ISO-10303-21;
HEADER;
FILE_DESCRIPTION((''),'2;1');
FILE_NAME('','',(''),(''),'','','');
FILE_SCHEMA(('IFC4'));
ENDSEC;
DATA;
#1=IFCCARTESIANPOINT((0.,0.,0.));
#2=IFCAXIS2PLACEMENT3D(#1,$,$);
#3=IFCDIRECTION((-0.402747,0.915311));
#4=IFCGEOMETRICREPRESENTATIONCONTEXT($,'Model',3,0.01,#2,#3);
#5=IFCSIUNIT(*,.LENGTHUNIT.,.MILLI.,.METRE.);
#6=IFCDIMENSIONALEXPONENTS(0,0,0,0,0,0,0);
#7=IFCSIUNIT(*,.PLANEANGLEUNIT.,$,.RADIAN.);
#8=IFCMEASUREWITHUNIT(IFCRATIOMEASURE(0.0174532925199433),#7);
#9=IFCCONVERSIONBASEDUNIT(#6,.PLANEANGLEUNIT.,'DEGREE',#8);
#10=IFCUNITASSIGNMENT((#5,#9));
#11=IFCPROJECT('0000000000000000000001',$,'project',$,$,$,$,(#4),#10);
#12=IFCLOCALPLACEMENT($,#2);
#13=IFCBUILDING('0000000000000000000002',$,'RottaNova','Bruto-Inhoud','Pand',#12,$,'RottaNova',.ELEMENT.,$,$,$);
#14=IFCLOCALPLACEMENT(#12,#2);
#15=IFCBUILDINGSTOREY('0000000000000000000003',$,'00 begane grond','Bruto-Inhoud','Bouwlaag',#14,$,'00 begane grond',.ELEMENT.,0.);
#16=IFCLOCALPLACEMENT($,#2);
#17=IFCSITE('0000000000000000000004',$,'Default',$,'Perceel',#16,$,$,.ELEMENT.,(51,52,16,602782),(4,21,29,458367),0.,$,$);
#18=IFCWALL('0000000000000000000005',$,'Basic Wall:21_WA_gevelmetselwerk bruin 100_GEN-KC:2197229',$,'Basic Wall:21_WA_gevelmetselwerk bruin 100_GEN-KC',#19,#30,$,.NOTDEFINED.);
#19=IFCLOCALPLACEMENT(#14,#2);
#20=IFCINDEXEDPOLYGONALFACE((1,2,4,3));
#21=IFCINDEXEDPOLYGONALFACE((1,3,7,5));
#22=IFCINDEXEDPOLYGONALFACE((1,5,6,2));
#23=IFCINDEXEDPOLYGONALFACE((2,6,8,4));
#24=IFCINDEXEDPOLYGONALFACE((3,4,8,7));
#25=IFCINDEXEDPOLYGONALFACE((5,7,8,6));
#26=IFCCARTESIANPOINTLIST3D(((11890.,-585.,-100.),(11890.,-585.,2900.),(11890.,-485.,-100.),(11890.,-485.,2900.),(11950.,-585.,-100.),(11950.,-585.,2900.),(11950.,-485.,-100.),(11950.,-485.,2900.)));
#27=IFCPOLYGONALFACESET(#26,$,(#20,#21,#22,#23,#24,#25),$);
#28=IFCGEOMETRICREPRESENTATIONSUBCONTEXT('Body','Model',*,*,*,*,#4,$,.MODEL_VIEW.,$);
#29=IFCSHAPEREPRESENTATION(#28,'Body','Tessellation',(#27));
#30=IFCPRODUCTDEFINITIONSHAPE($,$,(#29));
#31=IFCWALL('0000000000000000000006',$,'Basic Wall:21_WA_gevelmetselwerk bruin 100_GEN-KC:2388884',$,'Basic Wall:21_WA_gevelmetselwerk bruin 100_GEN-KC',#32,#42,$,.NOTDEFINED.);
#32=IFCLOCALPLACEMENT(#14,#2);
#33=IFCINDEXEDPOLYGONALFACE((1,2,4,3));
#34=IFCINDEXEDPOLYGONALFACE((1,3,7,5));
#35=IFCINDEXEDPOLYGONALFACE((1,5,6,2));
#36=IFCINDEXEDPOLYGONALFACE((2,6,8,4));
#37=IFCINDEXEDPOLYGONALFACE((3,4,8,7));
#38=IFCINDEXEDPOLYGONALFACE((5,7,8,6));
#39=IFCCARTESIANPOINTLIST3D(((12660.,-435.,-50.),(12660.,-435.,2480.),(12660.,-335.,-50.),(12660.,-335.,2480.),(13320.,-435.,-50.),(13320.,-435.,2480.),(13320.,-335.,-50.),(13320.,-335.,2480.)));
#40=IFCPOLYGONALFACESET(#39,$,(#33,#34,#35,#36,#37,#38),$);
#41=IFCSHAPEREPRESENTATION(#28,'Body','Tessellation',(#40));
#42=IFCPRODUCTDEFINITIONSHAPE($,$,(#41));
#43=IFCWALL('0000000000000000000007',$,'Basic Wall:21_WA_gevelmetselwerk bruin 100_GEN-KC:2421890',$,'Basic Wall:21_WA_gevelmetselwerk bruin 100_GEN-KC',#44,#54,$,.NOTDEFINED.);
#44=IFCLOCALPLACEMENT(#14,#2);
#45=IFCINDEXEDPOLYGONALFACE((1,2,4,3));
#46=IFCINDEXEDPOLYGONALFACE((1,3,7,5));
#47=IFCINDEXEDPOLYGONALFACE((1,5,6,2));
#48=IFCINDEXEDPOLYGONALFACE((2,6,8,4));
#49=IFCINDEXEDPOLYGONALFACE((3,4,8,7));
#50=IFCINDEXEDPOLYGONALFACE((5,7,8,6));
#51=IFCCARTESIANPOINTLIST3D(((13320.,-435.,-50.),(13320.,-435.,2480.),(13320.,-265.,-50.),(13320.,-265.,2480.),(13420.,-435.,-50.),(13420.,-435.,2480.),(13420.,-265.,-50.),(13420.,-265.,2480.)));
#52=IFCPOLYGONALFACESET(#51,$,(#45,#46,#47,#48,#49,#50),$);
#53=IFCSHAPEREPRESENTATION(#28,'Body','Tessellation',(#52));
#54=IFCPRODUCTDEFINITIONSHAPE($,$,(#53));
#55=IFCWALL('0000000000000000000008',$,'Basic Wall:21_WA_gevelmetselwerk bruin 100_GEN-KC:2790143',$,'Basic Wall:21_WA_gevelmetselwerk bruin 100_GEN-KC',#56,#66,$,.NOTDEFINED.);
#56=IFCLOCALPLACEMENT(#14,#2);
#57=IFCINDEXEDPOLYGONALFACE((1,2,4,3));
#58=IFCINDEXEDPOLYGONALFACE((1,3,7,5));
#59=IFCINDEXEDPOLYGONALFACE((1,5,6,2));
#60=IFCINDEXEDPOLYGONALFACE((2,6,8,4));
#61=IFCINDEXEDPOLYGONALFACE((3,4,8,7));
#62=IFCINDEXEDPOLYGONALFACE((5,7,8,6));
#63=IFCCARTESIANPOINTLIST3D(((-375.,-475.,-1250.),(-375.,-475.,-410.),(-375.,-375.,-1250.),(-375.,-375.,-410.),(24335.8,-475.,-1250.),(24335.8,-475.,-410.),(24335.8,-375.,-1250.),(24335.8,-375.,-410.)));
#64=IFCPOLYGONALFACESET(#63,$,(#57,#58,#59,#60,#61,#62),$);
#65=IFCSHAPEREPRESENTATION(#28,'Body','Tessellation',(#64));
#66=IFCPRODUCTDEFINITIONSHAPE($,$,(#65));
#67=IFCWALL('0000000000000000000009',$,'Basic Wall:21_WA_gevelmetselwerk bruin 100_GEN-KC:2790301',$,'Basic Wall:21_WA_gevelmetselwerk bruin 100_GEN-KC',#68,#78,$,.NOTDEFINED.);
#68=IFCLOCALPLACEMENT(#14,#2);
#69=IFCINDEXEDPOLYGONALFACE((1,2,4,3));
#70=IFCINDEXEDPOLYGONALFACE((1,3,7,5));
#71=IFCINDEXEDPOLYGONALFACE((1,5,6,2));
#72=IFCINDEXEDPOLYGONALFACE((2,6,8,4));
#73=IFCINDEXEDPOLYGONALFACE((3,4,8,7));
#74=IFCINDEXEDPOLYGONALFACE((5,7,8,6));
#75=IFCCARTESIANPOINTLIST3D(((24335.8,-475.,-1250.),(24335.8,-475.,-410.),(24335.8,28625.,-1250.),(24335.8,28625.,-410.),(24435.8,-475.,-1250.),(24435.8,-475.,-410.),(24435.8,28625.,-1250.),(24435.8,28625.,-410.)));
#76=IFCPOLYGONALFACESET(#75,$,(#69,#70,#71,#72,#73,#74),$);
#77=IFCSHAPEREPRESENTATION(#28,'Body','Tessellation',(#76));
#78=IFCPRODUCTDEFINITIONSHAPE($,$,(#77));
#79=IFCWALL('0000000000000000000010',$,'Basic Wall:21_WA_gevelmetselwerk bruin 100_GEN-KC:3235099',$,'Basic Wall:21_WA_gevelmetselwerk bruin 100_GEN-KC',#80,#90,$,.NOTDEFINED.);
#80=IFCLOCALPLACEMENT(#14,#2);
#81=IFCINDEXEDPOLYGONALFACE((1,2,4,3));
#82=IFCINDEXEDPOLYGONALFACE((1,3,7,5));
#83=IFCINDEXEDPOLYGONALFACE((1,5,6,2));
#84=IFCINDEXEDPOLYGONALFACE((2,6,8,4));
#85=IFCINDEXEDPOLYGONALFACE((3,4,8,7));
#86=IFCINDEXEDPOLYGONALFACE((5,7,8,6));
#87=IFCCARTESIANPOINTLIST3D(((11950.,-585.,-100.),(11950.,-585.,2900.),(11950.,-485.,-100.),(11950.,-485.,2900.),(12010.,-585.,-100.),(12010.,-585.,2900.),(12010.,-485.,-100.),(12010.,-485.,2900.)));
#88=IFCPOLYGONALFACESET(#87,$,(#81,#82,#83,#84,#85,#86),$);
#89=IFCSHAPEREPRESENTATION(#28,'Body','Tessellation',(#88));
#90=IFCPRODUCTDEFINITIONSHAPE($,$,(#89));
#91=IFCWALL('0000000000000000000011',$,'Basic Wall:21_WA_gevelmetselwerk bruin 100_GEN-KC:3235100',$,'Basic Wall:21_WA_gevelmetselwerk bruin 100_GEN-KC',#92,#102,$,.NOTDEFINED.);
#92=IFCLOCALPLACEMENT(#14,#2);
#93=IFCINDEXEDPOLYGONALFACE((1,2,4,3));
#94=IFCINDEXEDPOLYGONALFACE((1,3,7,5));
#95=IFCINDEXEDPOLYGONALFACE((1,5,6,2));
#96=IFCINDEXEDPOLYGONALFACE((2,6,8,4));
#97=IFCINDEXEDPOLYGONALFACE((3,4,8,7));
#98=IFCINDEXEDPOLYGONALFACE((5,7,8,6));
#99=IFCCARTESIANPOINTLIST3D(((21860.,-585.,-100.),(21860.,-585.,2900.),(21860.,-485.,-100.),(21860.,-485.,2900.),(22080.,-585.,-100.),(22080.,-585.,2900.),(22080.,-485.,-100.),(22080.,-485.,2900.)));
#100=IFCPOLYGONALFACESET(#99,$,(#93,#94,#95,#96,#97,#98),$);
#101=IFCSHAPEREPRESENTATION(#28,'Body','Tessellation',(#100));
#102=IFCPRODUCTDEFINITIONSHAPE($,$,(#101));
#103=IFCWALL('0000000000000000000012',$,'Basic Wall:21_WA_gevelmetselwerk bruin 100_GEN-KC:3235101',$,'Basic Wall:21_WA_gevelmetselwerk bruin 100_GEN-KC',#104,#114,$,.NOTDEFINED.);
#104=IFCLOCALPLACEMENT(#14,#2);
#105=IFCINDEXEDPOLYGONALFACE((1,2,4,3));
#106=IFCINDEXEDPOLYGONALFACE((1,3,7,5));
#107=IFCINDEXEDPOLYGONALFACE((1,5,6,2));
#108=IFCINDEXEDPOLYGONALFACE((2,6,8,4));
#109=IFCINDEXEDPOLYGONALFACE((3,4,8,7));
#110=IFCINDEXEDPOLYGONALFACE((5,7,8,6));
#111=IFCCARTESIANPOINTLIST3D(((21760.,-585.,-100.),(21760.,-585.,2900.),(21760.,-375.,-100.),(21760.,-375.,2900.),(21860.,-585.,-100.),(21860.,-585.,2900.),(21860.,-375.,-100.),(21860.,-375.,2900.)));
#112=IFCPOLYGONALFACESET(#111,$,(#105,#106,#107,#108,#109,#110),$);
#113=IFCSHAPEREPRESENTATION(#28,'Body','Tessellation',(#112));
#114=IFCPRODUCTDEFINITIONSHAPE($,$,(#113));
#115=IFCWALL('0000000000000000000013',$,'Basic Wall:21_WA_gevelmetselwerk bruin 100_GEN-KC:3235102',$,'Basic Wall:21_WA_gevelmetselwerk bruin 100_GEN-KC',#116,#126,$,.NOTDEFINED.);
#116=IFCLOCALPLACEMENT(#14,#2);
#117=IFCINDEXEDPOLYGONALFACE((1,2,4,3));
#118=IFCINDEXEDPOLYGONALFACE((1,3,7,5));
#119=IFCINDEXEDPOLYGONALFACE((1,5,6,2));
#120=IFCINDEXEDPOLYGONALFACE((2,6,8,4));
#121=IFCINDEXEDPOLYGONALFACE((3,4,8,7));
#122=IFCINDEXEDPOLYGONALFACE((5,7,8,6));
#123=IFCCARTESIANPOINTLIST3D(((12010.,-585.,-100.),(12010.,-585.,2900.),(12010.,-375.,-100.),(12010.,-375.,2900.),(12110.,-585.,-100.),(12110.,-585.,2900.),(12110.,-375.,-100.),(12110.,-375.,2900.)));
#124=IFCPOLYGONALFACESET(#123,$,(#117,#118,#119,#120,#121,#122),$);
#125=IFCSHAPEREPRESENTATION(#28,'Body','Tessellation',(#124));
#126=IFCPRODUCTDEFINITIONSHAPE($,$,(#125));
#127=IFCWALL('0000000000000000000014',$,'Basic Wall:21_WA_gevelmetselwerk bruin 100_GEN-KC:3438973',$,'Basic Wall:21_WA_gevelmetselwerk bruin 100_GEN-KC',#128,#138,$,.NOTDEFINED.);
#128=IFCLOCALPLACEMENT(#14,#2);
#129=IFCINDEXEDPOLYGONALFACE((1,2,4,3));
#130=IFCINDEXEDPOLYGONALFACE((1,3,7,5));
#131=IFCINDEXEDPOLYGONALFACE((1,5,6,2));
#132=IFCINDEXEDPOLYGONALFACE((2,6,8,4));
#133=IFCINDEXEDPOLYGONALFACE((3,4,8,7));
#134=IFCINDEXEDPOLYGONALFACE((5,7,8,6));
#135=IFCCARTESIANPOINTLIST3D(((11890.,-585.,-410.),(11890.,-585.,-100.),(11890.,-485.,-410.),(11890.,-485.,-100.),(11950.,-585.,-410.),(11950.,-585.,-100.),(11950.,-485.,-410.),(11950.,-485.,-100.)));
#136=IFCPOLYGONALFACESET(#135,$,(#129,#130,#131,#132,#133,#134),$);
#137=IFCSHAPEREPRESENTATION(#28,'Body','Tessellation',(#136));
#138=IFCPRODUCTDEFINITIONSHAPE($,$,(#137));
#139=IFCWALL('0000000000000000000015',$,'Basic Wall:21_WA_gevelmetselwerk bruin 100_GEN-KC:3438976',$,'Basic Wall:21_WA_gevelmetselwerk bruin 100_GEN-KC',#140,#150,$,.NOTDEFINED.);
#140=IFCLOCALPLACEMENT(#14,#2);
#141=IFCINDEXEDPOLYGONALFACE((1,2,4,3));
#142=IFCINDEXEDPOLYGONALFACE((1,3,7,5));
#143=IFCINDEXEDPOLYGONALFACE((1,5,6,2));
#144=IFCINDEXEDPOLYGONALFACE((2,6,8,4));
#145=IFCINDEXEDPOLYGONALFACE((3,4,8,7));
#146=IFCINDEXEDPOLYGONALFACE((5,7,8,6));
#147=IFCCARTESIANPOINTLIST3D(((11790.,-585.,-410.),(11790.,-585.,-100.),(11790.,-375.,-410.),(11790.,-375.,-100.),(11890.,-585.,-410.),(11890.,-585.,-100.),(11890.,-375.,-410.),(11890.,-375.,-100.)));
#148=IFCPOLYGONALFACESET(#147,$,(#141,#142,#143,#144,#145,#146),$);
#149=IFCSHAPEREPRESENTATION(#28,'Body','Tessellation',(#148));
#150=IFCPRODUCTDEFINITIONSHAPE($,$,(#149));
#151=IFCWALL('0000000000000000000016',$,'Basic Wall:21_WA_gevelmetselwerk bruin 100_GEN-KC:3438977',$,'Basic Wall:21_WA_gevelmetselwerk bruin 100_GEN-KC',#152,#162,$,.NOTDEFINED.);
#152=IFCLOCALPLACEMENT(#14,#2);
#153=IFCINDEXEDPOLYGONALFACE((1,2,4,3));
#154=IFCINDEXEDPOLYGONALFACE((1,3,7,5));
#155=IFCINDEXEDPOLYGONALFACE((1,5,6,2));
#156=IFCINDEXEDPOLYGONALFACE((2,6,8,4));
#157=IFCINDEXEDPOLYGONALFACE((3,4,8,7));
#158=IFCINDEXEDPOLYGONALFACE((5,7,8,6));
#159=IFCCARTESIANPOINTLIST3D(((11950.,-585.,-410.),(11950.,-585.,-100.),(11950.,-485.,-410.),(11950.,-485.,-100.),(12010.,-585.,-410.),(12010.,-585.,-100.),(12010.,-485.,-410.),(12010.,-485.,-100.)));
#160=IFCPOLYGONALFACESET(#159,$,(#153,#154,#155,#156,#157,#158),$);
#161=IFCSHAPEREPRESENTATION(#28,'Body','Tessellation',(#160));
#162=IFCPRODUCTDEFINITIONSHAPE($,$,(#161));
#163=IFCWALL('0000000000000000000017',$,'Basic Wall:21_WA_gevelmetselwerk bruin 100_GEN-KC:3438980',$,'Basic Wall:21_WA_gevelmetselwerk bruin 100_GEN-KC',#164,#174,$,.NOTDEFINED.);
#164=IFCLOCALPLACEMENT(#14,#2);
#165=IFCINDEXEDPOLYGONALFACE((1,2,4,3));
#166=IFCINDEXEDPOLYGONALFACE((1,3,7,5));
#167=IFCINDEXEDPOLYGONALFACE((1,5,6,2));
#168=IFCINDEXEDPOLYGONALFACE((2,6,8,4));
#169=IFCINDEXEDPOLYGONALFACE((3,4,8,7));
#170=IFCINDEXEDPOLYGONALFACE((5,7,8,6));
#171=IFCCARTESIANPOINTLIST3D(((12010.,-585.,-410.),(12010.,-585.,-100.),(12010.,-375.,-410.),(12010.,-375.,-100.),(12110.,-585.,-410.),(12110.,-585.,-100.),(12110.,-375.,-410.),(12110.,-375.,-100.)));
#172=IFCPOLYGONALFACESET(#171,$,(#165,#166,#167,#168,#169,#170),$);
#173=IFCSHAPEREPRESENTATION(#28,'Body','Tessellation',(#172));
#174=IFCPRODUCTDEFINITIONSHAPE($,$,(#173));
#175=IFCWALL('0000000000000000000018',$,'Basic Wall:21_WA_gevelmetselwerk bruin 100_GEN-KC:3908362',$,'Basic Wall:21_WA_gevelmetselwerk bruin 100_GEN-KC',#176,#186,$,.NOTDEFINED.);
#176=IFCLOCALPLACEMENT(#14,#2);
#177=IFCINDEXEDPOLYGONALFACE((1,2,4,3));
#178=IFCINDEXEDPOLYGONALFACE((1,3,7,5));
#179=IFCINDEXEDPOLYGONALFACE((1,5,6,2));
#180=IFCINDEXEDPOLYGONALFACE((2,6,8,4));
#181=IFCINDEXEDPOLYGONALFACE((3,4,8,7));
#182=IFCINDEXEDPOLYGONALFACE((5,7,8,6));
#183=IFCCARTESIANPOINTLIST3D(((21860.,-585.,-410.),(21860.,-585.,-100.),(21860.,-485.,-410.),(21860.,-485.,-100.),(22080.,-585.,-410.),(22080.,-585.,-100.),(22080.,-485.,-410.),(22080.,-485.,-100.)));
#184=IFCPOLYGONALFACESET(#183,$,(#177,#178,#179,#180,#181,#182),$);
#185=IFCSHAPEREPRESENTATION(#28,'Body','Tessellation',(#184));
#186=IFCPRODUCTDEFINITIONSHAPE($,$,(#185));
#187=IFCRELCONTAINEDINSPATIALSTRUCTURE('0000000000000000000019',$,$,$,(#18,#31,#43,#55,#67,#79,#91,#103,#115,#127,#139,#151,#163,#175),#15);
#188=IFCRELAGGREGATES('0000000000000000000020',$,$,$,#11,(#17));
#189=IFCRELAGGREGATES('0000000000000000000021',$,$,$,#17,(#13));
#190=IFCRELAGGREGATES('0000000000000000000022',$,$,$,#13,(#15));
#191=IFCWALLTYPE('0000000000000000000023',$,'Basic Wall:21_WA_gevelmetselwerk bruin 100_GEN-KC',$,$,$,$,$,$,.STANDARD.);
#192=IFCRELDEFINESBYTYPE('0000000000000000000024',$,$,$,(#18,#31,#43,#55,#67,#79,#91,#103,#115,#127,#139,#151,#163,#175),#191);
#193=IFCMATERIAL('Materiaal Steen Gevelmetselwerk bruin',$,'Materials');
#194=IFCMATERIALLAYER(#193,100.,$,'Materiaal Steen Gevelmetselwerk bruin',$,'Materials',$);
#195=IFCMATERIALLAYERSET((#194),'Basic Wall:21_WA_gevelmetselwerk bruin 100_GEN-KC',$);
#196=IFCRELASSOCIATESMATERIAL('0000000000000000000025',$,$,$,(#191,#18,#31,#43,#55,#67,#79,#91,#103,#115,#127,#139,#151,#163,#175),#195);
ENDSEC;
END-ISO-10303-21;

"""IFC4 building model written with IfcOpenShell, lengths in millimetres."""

from ifc_helpers import new_model, entity, si_unit, converted_unit, direction, frame, frame_2d, origin, place, context, subcontext, project, spatial, rectangle, extrude, material, layer, layer_set, type_object, element, save


model = new_model("IFC4")

# Units and contexts
model_context = context("Model", 3, precision=0.01, world=origin(), true_north=direction((-0.402747, 0.915311)))
body_context = subcontext(model_context, "Body", "Model", "MODEL_VIEW")
ifc_project = project(units=[si_unit("LENGTHUNIT", "METRE", prefix="MILLI"), converted_unit("PLANEANGLEUNIT", "DEGREE", entity("IfcRatioMeasure", 0.0174532925199433), si_unit("PLANEANGLEUNIT", "RADIAN"), dimensions=[0, 0, 0, 0, 0, 0, 0])], contexts=[model_context])

# Site, building, storey
site_placement = place(None, origin())
site = spatial("IfcSite", under=ifc_project, at=site_placement, Name="Default", ObjectType="Perceel", CompositionType="ELEMENT", RefLatitude=(51, 52, 16, 602782), RefLongitude=(4, 21, 29, 458367), RefElevation=0.0)
building_placement = place(None, origin())
building = spatial("IfcBuilding", under=site, at=building_placement, Name="RottaNova", Description="Bruto-Inhoud", ObjectType="Pand", LongName="RottaNova", CompositionType="ELEMENT")
storey_placement = place(building_placement, origin())
storey = spatial("IfcBuildingStorey", under=building, at=storey_placement, Name="00 begane grond", Description="Bruto-Inhoud", ObjectType="Bouwlaag", LongName="00 begane grond", CompositionType="ELEMENT", Elevation=0.0)

# Walls
ifc_material_1 = material(Name="Materiaal Steen Gevelmetselwerk bruin", Category="Materials")
ifc_layer_1 = layer(ifc_material_1, 100.0, Name="Materiaal Steen Gevelmetselwerk bruin", Category="Materials")
ifc_layer_set_1 = layer_set([ifc_layer_1], Name="Basic Wall:21_WA_gevelmetselwerk bruin 100_GEN-KC")
wall_type_1 = type_object("IfcWallType", Name="Basic Wall:21_WA_gevelmetselwerk bruin 100_GEN-KC", PredefinedType="STANDARD", material=ifc_layer_set_1)
wall_1_placement = place(storey_placement, frame((11890.0, -535.0, -100.0)))
element("IfcWall", 1, at=wall_1_placement, inside=storey, type_object=wall_type_1, material=ifc_layer_set_1, Name="Basic Wall:21_WA_gevelmetselwerk bruin 100_GEN-KC:2197229", ObjectType="Basic Wall:21_WA_gevelmetselwerk bruin 100_GEN-KC", PredefinedType="NOTDEFINED", context=body_context, shape_type="SweptSolid", body=[
    extrude(rectangle(XDim=60.0, YDim=100.0, at=frame_2d((30.0, 0.0), x_axis=(-1.0, 0.0))), origin(), (0.0, 0.0, 1.0), 3000.0),
])
wall_2_placement = place(storey_placement, frame((12660.0, -385.0, -50.0)))
element("IfcWall", 2, at=wall_2_placement, inside=storey, type_object=wall_type_1, material=ifc_layer_set_1, Name="Basic Wall:21_WA_gevelmetselwerk bruin 100_GEN-KC:2388884", ObjectType="Basic Wall:21_WA_gevelmetselwerk bruin 100_GEN-KC", PredefinedType="NOTDEFINED", context=body_context, shape_type="SweptSolid", body=[
    extrude(rectangle(XDim=660.0, YDim=100.0, at=frame_2d((330.0, 0.0), x_axis=(-1.0, 0.0))), origin(), (0.0, 0.0, 1.0), 2530.0),
])
wall_3_placement = place(storey_placement, frame((13370.0, -265.0, -50.0), z_axis=(0.0, 0.0, 1.0), x_axis=(0.0, -1.0, 0.0)))
element("IfcWall", 3, at=wall_3_placement, inside=storey, type_object=wall_type_1, material=ifc_layer_set_1, Name="Basic Wall:21_WA_gevelmetselwerk bruin 100_GEN-KC:2421890", ObjectType="Basic Wall:21_WA_gevelmetselwerk bruin 100_GEN-KC", PredefinedType="NOTDEFINED", context=body_context, shape_type="SweptSolid", body=[
    extrude(rectangle(XDim=170.0, YDim=100.0, at=frame_2d((85.0, 0.0), x_axis=(-1.0, 0.0))), origin(), (0.0, 0.0, 1.0), 2530.0),
])
wall_4_placement = place(storey_placement, frame((24335.8, -425.0, -1250.0), z_axis=(0.0, 0.0, 1.0), x_axis=(-1.0, 0.0, 0.0)))
element("IfcWall", 4, at=wall_4_placement, inside=storey, type_object=wall_type_1, material=ifc_layer_set_1, Name="Basic Wall:21_WA_gevelmetselwerk bruin 100_GEN-KC:2790143", ObjectType="Basic Wall:21_WA_gevelmetselwerk bruin 100_GEN-KC", PredefinedType="NOTDEFINED", context=body_context, shape_type="SweptSolid", body=[
    extrude(rectangle(XDim=24710.8, YDim=100.0, at=frame_2d((12355.4, 0.0), x_axis=(-1.0, 0.0))), origin(), (0.0, 0.0, 1.0), 840.0),
])
wall_5_placement = place(storey_placement, frame((24385.8, -475.0, -1250.0), z_axis=(0.0, 0.0, 1.0), x_axis=(0.0, 1.0, 0.0)))
element("IfcWall", 5, at=wall_5_placement, inside=storey, type_object=wall_type_1, material=ifc_layer_set_1, Name="Basic Wall:21_WA_gevelmetselwerk bruin 100_GEN-KC:2790301", ObjectType="Basic Wall:21_WA_gevelmetselwerk bruin 100_GEN-KC", PredefinedType="NOTDEFINED", context=body_context, shape_type="SweptSolid", body=[
    extrude(rectangle(XDim=29100.0, YDim=100.0, at=frame_2d((14550.0, 0.0), x_axis=(-1.0, 0.0))), origin(), (0.0, 0.0, 1.0), 840.0),
])
wall_6_placement = place(storey_placement, frame((12010.0, -535.0, -100.0), z_axis=(0.0, 0.0, 1.0), x_axis=(-1.0, 0.0, 0.0)))
element("IfcWall", 6, at=wall_6_placement, inside=storey, type_object=wall_type_1, material=ifc_layer_set_1, Name="Basic Wall:21_WA_gevelmetselwerk bruin 100_GEN-KC:3235099", ObjectType="Basic Wall:21_WA_gevelmetselwerk bruin 100_GEN-KC", PredefinedType="NOTDEFINED", context=body_context, shape_type="SweptSolid", body=[
    extrude(rectangle(XDim=60.0, YDim=100.0, at=frame_2d((30.0, 0.0), x_axis=(-1.0, 0.0))), origin(), (0.0, 0.0, 1.0), 3000.0),
])
wall_7_placement = place(storey_placement, frame((22080.0, -535.0, -100.0), z_axis=(0.0, 0.0, 1.0), x_axis=(-1.0, 0.0, 0.0)))
element("IfcWall", 7, at=wall_7_placement, inside=storey, type_object=wall_type_1, material=ifc_layer_set_1, Name="Basic Wall:21_WA_gevelmetselwerk bruin 100_GEN-KC:3235100", ObjectType="Basic Wall:21_WA_gevelmetselwerk bruin 100_GEN-KC", PredefinedType="NOTDEFINED", context=body_context, shape_type="SweptSolid", body=[
    extrude(rectangle(XDim=220.0, YDim=100.0, at=frame_2d((110.0, 0.0), x_axis=(-1.0, 0.0))), origin(), (0.0, 0.0, 1.0), 3000.0),
])
wall_8_placement = place(storey_placement, frame((21810.0, -585.0, -100.0), z_axis=(0.0, 0.0, 1.0), x_axis=(0.0, 1.0, 0.0)))
element("IfcWall", 8, at=wall_8_placement, inside=storey, type_object=wall_type_1, material=ifc_layer_set_1, Name="Basic Wall:21_WA_gevelmetselwerk bruin 100_GEN-KC:3235101", ObjectType="Basic Wall:21_WA_gevelmetselwerk bruin 100_GEN-KC", PredefinedType="NOTDEFINED", context=body_context, shape_type="SweptSolid", body=[
    extrude(rectangle(XDim=210.0, YDim=100.0, at=frame_2d((105.0, 0.0), x_axis=(-1.0, 0.0))), origin(), (0.0, 0.0, 1.0), 3000.0),
])
wall_9_placement = place(storey_placement, frame((12060.0, -585.0, -100.0), z_axis=(0.0, 0.0, 1.0), x_axis=(0.0, 1.0, 0.0)))
element("IfcWall", 9, at=wall_9_placement, inside=storey, type_object=wall_type_1, material=ifc_layer_set_1, Name="Basic Wall:21_WA_gevelmetselwerk bruin 100_GEN-KC:3235102", ObjectType="Basic Wall:21_WA_gevelmetselwerk bruin 100_GEN-KC", PredefinedType="NOTDEFINED", context=body_context, shape_type="SweptSolid", body=[
    extrude(rectangle(XDim=210.0, YDim=100.0, at=frame_2d((105.0, 0.0), x_axis=(-1.0, 0.0))), origin(), (0.0, 0.0, 1.0), 3000.0),
])
wall_10_placement = place(storey_placement, frame((11890.0, -535.0, -410.0)))
element("IfcWall", 10, at=wall_10_placement, inside=storey, type_object=wall_type_1, material=ifc_layer_set_1, Name="Basic Wall:21_WA_gevelmetselwerk bruin 100_GEN-KC:3438973", ObjectType="Basic Wall:21_WA_gevelmetselwerk bruin 100_GEN-KC", PredefinedType="NOTDEFINED", context=body_context, shape_type="SweptSolid", body=[
    extrude(rectangle(XDim=60.0, YDim=100.0, at=frame_2d((30.0, 0.0), x_axis=(-1.0, 0.0))), origin(), (0.0, 0.0, 1.0), 310.0),
])
wall_11_placement = place(storey_placement, frame((11840.0, -585.0, -410.0), z_axis=(0.0, 0.0, 1.0), x_axis=(0.0, 1.0, 0.0)))
element("IfcWall", 11, at=wall_11_placement, inside=storey, type_object=wall_type_1, material=ifc_layer_set_1, Name="Basic Wall:21_WA_gevelmetselwerk bruin 100_GEN-KC:3438976", ObjectType="Basic Wall:21_WA_gevelmetselwerk bruin 100_GEN-KC", PredefinedType="NOTDEFINED", context=body_context, shape_type="SweptSolid", body=[
    extrude(rectangle(XDim=210.0, YDim=100.0, at=frame_2d((105.0, 0.0), x_axis=(-1.0, 0.0))), origin(), (0.0, 0.0, 1.0), 310.0),
])
wall_12_placement = place(storey_placement, frame((12010.0, -535.0, -410.0), z_axis=(0.0, 0.0, 1.0), x_axis=(-1.0, 0.0, 0.0)))
element("IfcWall", 12, at=wall_12_placement, inside=storey, type_object=wall_type_1, material=ifc_layer_set_1, Name="Basic Wall:21_WA_gevelmetselwerk bruin 100_GEN-KC:3438977", ObjectType="Basic Wall:21_WA_gevelmetselwerk bruin 100_GEN-KC", PredefinedType="NOTDEFINED", context=body_context, shape_type="SweptSolid", body=[
    extrude(rectangle(XDim=60.0, YDim=100.0, at=frame_2d((30.0, 0.0), x_axis=(-1.0, 0.0))), origin(), (0.0, 0.0, 1.0), 310.0),
])
wall_13_placement = place(storey_placement, frame((12060.0, -585.0, -410.0), z_axis=(0.0, 0.0, 1.0), x_axis=(0.0, 1.0, 0.0)))
element("IfcWall", 13, at=wall_13_placement, inside=storey, type_object=wall_type_1, material=ifc_layer_set_1, Name="Basic Wall:21_WA_gevelmetselwerk bruin 100_GEN-KC:3438980", ObjectType="Basic Wall:21_WA_gevelmetselwerk bruin 100_GEN-KC", PredefinedType="NOTDEFINED", context=body_context, shape_type="SweptSolid", body=[
    extrude(rectangle(XDim=210.0, YDim=100.0, at=frame_2d((105.0, 0.0), x_axis=(-1.0, 0.0))), origin(), (0.0, 0.0, 1.0), 310.0),
])
wall_14_placement = place(storey_placement, frame((22080.0, -535.0, -410.0), z_axis=(0.0, 0.0, 1.0), x_axis=(-1.0, 0.0, 0.0)))
element("IfcWall", 14, at=wall_14_placement, inside=storey, type_object=wall_type_1, material=ifc_layer_set_1, Name="Basic Wall:21_WA_gevelmetselwerk bruin 100_GEN-KC:3908362", ObjectType="Basic Wall:21_WA_gevelmetselwerk bruin 100_GEN-KC", PredefinedType="NOTDEFINED", context=body_context, shape_type="SweptSolid", body=[
    extrude(rectangle(XDim=220.0, YDim=100.0, at=frame_2d((110.0, 0.0), x_axis=(-1.0, 0.0))), origin(), (0.0, 0.0, 1.0), 310.0),
])

save(model, "model.ifc")
